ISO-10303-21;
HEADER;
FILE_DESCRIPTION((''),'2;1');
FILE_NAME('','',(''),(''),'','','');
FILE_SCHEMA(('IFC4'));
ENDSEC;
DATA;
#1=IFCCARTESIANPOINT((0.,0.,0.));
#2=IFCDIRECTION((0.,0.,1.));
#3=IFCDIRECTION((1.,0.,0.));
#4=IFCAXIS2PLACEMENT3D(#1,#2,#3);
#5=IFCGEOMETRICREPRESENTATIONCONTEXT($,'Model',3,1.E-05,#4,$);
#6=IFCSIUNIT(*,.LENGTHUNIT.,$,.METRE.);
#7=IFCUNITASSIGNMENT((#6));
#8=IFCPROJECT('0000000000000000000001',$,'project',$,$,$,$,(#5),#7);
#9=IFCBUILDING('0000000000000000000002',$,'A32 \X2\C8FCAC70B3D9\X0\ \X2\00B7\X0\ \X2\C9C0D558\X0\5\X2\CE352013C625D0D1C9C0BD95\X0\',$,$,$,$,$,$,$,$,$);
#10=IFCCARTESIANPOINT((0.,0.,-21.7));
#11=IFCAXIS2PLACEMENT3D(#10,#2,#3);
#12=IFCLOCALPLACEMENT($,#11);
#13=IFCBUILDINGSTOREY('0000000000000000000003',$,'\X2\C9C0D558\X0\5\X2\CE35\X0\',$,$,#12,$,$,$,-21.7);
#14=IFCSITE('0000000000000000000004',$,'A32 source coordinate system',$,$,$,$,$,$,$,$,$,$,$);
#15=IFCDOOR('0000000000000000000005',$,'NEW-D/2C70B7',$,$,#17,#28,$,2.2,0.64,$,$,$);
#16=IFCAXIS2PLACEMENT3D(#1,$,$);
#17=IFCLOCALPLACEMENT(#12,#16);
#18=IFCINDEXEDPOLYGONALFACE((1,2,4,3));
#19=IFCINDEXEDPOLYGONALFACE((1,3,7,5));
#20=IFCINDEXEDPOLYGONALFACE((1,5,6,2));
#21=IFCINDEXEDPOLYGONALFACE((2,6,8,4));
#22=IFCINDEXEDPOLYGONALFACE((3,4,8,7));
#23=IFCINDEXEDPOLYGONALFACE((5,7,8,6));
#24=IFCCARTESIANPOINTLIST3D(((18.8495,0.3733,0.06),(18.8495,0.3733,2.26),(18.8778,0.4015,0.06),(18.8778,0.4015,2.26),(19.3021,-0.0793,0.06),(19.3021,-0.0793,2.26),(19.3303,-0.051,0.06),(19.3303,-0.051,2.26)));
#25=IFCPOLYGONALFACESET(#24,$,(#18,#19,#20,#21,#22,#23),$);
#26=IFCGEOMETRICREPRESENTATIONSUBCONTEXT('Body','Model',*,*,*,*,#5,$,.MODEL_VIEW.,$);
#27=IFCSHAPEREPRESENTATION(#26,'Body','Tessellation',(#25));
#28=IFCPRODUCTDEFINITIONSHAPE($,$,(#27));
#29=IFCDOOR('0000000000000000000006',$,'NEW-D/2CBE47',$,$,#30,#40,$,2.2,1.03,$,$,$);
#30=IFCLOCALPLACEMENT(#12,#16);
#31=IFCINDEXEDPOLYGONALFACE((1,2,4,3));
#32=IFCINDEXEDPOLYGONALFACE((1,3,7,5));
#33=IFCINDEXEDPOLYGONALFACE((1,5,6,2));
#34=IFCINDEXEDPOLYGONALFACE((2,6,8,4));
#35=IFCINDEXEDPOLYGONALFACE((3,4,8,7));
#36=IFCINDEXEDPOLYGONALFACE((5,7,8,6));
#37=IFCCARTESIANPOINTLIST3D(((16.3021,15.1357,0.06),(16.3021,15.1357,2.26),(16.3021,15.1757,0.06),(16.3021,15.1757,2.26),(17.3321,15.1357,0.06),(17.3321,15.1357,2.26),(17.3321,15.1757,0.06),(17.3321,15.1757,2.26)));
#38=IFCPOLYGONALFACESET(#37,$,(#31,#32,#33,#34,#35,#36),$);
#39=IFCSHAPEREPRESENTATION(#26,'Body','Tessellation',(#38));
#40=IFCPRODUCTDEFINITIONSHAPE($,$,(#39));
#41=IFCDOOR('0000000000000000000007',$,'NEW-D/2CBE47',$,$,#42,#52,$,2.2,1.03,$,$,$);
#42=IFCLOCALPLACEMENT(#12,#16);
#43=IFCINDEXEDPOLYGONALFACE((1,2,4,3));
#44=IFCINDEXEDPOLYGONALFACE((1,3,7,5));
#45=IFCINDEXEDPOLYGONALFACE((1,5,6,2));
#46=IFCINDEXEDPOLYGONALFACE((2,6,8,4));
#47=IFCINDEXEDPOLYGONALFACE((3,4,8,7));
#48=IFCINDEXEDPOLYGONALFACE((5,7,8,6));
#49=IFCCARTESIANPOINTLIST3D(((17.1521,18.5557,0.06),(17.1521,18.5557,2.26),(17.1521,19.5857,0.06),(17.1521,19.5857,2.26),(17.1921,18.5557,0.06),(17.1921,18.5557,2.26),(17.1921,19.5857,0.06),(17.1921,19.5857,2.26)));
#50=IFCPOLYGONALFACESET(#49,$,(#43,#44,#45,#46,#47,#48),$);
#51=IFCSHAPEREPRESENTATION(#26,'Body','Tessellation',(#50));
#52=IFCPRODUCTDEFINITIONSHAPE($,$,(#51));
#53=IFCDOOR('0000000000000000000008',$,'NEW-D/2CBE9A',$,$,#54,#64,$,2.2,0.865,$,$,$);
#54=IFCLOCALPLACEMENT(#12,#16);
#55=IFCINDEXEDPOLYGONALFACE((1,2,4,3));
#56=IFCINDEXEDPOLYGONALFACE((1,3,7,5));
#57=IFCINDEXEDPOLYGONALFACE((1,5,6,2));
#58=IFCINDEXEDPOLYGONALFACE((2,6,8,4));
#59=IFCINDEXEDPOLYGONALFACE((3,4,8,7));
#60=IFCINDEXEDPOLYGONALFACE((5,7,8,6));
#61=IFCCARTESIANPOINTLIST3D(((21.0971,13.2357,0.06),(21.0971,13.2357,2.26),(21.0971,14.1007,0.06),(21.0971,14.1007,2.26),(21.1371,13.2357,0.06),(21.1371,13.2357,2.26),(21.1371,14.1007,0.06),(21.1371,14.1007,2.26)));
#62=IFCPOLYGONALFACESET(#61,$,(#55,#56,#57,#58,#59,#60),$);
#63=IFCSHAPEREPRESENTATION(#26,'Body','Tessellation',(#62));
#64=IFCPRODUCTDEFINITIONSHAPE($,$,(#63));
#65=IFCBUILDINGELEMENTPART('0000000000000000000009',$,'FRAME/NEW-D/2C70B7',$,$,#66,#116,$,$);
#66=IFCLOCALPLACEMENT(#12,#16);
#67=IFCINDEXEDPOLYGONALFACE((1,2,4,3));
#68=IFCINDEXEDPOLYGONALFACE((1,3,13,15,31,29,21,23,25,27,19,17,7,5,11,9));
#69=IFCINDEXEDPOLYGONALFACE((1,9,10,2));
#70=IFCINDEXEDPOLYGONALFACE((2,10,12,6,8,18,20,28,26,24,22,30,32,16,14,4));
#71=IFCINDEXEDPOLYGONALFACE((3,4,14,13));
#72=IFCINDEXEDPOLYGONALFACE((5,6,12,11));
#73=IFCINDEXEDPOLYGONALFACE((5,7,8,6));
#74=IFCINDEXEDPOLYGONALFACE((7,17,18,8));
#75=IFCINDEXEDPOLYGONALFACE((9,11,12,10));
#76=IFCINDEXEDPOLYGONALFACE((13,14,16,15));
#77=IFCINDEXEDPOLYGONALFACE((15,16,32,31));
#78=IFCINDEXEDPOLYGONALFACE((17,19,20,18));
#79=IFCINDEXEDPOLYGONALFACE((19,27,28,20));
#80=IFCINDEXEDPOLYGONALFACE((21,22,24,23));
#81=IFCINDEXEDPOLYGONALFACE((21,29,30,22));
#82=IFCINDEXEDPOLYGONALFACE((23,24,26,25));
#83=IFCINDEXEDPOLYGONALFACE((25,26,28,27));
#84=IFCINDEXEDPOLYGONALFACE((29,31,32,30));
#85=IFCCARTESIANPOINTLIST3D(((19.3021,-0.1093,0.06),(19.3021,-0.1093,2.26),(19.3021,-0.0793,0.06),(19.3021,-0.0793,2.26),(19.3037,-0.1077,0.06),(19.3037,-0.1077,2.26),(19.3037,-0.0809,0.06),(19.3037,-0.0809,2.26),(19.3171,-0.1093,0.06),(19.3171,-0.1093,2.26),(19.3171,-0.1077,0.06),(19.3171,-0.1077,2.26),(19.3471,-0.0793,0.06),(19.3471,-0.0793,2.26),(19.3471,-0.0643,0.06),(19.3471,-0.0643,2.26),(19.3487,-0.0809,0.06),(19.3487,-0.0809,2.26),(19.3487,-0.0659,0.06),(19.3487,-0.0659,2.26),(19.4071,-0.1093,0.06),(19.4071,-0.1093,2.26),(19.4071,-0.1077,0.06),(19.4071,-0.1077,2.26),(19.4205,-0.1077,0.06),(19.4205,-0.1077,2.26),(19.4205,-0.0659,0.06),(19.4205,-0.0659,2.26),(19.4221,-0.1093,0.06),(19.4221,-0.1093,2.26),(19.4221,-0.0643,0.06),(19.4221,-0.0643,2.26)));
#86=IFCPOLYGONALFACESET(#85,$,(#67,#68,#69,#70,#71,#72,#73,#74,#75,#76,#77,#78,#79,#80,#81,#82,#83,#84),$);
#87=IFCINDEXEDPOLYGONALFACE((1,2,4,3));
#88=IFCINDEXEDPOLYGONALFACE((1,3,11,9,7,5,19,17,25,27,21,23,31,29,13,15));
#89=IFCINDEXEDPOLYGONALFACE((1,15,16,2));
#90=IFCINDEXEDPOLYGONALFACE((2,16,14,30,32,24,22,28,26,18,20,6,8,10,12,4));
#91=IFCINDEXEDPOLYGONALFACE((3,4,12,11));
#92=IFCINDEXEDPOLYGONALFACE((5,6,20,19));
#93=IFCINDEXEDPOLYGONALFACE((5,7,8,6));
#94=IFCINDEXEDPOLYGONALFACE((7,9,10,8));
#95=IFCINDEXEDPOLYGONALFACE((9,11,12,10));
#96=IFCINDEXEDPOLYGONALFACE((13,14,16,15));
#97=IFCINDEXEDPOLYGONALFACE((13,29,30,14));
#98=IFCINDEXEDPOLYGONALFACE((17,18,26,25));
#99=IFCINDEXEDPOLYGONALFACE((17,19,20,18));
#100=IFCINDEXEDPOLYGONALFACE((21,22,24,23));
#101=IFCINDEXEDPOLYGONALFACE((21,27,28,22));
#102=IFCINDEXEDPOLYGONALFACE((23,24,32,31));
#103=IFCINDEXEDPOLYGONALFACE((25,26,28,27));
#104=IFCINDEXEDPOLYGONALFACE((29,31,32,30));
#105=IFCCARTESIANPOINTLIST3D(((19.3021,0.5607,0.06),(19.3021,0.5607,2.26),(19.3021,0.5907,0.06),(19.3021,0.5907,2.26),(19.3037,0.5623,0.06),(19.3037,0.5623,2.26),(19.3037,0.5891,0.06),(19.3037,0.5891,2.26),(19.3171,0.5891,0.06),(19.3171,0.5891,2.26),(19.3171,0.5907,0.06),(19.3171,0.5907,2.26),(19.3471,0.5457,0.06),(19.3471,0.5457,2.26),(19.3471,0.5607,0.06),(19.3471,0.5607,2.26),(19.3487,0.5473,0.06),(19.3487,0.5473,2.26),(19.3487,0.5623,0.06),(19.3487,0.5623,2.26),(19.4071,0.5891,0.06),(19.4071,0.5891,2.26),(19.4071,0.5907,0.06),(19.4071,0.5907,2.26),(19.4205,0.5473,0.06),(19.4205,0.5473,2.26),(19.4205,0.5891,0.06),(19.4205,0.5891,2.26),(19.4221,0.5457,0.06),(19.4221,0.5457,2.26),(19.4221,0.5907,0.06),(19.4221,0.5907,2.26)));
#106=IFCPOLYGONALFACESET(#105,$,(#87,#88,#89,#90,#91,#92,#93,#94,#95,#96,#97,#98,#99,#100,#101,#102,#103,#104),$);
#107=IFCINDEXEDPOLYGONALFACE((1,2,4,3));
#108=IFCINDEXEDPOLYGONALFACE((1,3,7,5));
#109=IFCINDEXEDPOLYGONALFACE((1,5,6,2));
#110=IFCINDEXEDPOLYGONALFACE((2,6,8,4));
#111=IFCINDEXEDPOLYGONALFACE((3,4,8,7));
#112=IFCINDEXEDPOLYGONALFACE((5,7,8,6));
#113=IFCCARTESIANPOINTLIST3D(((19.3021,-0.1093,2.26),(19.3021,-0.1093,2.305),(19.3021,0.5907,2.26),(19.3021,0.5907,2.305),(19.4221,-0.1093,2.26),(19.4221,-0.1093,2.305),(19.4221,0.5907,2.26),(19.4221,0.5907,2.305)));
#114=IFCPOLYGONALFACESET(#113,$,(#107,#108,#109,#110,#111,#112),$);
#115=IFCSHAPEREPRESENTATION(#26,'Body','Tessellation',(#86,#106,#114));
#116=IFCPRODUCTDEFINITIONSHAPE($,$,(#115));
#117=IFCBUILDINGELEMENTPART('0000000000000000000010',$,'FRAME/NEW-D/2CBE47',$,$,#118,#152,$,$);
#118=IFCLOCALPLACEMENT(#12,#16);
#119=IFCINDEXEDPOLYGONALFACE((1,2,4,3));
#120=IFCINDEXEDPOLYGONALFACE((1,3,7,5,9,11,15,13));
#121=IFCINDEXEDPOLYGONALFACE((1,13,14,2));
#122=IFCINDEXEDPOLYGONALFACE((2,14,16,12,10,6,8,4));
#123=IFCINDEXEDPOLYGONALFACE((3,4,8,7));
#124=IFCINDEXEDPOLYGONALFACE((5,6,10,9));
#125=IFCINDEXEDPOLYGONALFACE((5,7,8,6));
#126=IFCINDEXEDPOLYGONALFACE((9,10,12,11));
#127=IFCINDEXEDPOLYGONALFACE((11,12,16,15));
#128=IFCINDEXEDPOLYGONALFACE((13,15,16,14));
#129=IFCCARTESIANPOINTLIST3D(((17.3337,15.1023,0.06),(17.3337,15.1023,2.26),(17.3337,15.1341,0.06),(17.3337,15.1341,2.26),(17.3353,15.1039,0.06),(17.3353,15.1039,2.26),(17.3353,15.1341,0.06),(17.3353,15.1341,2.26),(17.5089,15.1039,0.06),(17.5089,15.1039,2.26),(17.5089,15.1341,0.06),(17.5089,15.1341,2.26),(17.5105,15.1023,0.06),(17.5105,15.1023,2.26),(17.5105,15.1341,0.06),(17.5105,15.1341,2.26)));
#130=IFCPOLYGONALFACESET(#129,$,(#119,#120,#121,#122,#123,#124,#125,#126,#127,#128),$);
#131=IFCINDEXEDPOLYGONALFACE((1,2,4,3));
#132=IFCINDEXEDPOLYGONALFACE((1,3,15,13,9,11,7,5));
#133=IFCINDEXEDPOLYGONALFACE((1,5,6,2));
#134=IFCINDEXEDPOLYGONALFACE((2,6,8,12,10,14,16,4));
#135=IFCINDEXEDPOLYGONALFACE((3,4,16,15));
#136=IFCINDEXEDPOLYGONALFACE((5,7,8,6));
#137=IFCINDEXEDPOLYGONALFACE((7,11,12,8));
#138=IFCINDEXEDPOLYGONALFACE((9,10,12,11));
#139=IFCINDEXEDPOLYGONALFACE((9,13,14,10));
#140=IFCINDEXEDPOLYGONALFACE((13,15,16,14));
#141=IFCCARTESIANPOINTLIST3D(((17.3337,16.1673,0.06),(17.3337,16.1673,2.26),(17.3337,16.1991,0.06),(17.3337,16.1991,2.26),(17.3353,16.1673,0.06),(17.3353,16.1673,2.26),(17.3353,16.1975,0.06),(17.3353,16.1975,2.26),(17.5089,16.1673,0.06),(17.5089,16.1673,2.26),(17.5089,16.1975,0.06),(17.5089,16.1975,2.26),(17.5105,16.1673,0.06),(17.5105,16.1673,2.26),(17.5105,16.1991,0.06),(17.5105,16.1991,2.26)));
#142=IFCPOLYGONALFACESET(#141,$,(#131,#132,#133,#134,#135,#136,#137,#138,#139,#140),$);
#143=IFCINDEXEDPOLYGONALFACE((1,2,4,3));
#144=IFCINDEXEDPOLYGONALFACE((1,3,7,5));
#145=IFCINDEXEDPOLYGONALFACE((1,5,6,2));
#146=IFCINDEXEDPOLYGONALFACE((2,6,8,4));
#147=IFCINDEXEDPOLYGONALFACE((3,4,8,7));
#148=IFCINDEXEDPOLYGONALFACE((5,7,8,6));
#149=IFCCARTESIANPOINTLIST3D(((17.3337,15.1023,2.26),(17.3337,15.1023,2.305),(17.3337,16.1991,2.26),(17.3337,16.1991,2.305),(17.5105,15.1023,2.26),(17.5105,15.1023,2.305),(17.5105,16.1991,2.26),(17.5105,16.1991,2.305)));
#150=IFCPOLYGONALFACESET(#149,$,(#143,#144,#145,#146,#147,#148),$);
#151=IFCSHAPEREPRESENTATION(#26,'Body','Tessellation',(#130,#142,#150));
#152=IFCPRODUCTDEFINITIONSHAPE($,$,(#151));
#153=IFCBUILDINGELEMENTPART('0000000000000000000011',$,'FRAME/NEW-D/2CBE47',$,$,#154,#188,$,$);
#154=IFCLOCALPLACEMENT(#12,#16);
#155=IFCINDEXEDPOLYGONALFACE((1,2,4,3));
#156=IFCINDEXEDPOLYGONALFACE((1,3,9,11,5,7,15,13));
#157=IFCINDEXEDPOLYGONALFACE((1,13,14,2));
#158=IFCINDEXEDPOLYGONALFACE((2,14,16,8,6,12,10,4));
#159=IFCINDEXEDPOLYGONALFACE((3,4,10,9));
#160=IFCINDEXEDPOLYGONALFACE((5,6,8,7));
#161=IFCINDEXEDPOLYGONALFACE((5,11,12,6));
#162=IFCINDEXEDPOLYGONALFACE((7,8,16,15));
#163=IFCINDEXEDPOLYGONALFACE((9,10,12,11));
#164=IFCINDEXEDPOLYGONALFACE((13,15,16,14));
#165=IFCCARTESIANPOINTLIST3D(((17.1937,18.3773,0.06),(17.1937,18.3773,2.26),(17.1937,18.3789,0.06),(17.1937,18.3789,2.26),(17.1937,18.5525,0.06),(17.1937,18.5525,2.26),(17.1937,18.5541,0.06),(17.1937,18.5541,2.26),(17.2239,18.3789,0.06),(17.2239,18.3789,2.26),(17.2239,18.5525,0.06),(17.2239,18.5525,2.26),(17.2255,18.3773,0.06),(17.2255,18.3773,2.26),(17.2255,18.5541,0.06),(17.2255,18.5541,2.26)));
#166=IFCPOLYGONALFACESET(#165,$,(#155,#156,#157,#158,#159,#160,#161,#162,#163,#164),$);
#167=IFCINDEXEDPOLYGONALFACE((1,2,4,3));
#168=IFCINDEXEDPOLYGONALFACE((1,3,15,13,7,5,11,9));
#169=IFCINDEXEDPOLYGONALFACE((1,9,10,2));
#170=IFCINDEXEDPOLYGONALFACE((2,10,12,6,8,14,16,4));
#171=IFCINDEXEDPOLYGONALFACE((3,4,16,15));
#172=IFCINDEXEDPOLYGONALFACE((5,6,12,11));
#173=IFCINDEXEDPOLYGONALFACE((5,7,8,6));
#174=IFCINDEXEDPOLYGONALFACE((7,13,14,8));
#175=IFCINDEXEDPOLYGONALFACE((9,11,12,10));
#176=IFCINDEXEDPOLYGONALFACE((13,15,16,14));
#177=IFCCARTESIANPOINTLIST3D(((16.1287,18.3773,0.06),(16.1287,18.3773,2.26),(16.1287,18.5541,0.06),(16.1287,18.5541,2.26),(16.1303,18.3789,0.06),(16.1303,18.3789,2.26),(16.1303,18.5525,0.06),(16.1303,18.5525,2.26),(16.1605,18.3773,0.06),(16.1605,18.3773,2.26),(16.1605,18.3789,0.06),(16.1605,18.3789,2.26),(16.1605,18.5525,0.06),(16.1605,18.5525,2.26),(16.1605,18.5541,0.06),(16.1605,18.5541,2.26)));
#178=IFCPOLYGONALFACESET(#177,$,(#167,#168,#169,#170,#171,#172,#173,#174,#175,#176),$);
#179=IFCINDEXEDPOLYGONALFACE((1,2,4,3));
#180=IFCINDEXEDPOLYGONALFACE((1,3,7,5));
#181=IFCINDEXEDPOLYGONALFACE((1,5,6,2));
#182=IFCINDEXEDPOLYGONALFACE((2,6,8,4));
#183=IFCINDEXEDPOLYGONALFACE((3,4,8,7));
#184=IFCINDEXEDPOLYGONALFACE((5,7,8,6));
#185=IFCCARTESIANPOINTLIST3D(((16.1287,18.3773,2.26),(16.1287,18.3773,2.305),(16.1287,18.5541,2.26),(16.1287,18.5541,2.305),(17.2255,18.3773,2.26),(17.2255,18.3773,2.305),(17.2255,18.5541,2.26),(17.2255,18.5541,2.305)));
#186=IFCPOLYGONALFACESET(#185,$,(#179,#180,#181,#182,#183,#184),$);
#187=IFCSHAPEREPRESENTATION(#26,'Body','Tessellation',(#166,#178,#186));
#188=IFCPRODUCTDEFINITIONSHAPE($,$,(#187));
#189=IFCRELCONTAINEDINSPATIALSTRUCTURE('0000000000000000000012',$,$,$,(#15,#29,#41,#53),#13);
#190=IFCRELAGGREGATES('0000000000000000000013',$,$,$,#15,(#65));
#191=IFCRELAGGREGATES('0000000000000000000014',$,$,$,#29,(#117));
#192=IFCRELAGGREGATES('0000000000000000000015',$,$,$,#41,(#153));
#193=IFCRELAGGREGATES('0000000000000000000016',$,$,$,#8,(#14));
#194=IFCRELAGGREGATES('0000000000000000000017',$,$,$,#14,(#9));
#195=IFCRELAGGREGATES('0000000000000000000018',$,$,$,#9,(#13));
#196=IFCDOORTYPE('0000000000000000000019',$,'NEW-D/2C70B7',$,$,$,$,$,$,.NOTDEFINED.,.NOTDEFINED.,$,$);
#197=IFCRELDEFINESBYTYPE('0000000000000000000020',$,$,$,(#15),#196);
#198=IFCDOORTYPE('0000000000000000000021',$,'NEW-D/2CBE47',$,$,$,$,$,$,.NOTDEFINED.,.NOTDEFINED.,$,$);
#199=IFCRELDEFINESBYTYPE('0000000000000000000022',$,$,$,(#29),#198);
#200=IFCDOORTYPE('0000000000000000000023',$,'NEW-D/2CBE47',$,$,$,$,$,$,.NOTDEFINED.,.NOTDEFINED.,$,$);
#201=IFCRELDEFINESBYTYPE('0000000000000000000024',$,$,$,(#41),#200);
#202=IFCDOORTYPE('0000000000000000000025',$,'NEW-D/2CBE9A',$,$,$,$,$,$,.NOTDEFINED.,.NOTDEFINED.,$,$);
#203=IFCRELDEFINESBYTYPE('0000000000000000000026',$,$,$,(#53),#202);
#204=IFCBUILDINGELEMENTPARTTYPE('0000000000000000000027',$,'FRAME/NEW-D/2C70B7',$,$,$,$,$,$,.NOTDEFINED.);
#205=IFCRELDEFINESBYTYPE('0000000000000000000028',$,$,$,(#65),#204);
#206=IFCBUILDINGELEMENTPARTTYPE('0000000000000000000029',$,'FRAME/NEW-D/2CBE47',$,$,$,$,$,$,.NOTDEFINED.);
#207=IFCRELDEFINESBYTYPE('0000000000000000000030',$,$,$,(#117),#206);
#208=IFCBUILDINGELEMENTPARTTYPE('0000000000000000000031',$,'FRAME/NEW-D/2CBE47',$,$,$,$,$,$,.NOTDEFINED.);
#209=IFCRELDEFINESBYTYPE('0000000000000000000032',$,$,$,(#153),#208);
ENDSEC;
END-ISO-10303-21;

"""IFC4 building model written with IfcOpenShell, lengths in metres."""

from ifc_helpers import new_model, si_unit, frame, origin, origin_with_axes, place, context, subcontext, project, spatial, polyline, outline, extrude, source, transform, mapped, type_object, type_shapes, element, aggregate, save


model = new_model("IFC4")

# Units and contexts
model_context = context("Model", 3, precision=1e-05, world=origin_with_axes())
body_context = subcontext(model_context, "Body", "Model", "MODEL_VIEW")
ifc_project = project(units=[si_unit("LENGTHUNIT", "METRE")], contexts=[model_context])

# Site, building, storey
site = spatial("IfcSite", under=ifc_project, Name="A32 source coordinate system")
building = spatial("IfcBuilding", under=site, Name="A32 주거동 · 지하5층–옥탑지붕")
storey_placement = place(None, frame((0.0, 0.0, -21.7), z_axis=(0.0, 0.0, 1.0), x_axis=(1.0, 0.0, 0.0)))
storey = spatial("IfcBuildingStorey", under=building, at=storey_placement, Name="지하5층", Elevation=-21.7)

# Doors
door_type_1 = type_object("IfcDoorType", Name="NEW-D/2C70B7", OperationType="NOTDEFINED", PredefinedType="NOTDEFINED")
shared_shape_1 = source(origin(), body_context, "Body", "SweptSolid", [
    extrude(outline(polyline([(18.8778, 0.4015), (19.3303, -0.051), (19.3021, -0.0793), (18.8495, 0.3733), (18.8778, 0.4015)])), frame((0.0, 0.0, 0.06)), (0.0, 0.0, 1.0), 2.2),
])
type_shapes(door_type_1, [shared_shape_1])
door_1_placement = place(storey_placement, origin_with_axes())
door_1 = element("IfcDoor", 1, at=door_1_placement, inside=storey, type_object=door_type_1, Name="NEW-D/2C70B7", OverallHeight=2.2, OverallWidth=0.64, context=body_context, shape_type="MappedRepresentation", body=[
    mapped(shared_shape_1, transform((0.0, 0.0, 0.0), scale=1.0)),
])
door_type_2 = type_object("IfcDoorType", Name="NEW-D/2CBE47", OperationType="NOTDEFINED", PredefinedType="NOTDEFINED")
shared_shape_2 = source(origin(), body_context, "Body", "SweptSolid", [
    extrude(outline(polyline([(16.3021, 15.1757), (17.3321, 15.1757), (17.3321, 15.1357), (16.3021, 15.1357), (16.3021, 15.1757)])), frame((0.0, 0.0, 0.06)), (0.0, 0.0, 1.0), 2.2),
])
type_shapes(door_type_2, [shared_shape_2])
door_2_placement = place(storey_placement, origin_with_axes())
door_2 = element("IfcDoor", 2, at=door_2_placement, inside=storey, type_object=door_type_2, Name="NEW-D/2CBE47", OverallHeight=2.2, OverallWidth=1.03, context=body_context, shape_type="MappedRepresentation", body=[
    mapped(shared_shape_2, transform((0.0, 0.0, 0.0), scale=1.0)),
])
door_type_3 = type_object("IfcDoorType", Name="NEW-D/2CBE47", OperationType="NOTDEFINED", PredefinedType="NOTDEFINED")
shared_shape_3 = source(origin(), body_context, "Body", "SweptSolid", [
    extrude(outline(polyline([(17.1921, 18.5557), (17.1521, 18.5557), (17.1521, 19.5857), (17.1921, 19.5857), (17.1921, 18.5557)])), frame((0.0, 0.0, 0.06)), (0.0, 0.0, 1.0), 2.2),
])
type_shapes(door_type_3, [shared_shape_3])
door_3_placement = place(storey_placement, origin_with_axes())
door_3 = element("IfcDoor", 3, at=door_3_placement, inside=storey, type_object=door_type_3, Name="NEW-D/2CBE47", OverallHeight=2.2, OverallWidth=1.03, context=body_context, shape_type="MappedRepresentation", body=[
    mapped(shared_shape_3, transform((0.0, 0.0, 0.0), scale=1.0)),
])

# Door
door_type_4 = type_object("IfcDoorType", Name="NEW-D/2CBE9A", OperationType="NOTDEFINED", PredefinedType="NOTDEFINED")
shared_shape_4 = source(origin(), body_context, "Body", "SweptSolid", [
    extrude(outline(polyline([(21.1371, 13.2357), (21.0971, 13.2357), (21.0971, 14.1007), (21.1371, 14.1007), (21.1371, 13.2357)])), frame((0.0, 0.0, 0.06)), (0.0, 0.0, 1.0), 2.2),
])
type_shapes(door_type_4, [shared_shape_4])
door_4_placement = place(storey_placement, origin_with_axes())
element("IfcDoor", 4, at=door_4_placement, inside=storey, type_object=door_type_4, Name="NEW-D/2CBE9A", OverallHeight=2.2, OverallWidth=0.865, context=body_context, shape_type="MappedRepresentation", body=[
    mapped(shared_shape_4, transform((0.0, 0.0, 0.0), scale=1.0)),
])

# Building element parts
building_element_part_type_1 = type_object("IfcBuildingElementPartType", Name="FRAME/NEW-D/2C70B7", PredefinedType="NOTDEFINED")
shared_shape_5 = source(origin(), body_context, "Body", "SweptSolid", [
    extrude(outline(polyline([(19.3021, -0.1093), (19.3021, -0.0793), (19.3471, -0.0793), (19.3471, -0.0643), (19.4221, -0.0643), (19.4221, -0.1093), (19.4071, -0.1093), (19.4071, -0.1077), (19.4205, -0.1077), (19.4205, -0.0659), (19.3487, -0.0659), (19.3487, -0.0809), (19.3037, -0.0809), (19.3037, -0.1077), (19.3171, -0.1077), (19.3171, -0.1093), (19.3021, -0.1093)])), frame((0.0, 0.0, 0.06)), (0.0, 0.0, 1.0), 2.2),
    extrude(outline(polyline([(19.3037, 0.5623), (19.3487, 0.5623), (19.3487, 0.5473), (19.4205, 0.5473), (19.4205, 0.5891), (19.4071, 0.5891), (19.4071, 0.5907), (19.4221, 0.5907), (19.4221, 0.5457), (19.3471, 0.5457), (19.3471, 0.5607), (19.3021, 0.5607), (19.3021, 0.5907), (19.3171, 0.5907), (19.3171, 0.5891), (19.3037, 0.5891), (19.3037, 0.5623)])), frame((0.0, 0.0, 0.06)), (0.0, 0.0, 1.0), 2.2),
    extrude(outline(polyline([(19.4221, -0.1093), (19.4221, 0.5907), (19.3021, 0.5907), (19.3021, -0.1093), (19.4221, -0.1093)])), frame((0.0, 0.0, 2.26)), (0.0, 0.0, 1.0), 0.045),
])
type_shapes(building_element_part_type_1, [shared_shape_5])
building_element_part_1_placement = place(door_1_placement, origin_with_axes())
building_element_part_1 = element("IfcBuildingElementPart", 5, at=building_element_part_1_placement, type_object=building_element_part_type_1, Name="FRAME/NEW-D/2C70B7", context=body_context, shape_type="MappedRepresentation", body=[
    mapped(shared_shape_5, transform((0.0, 0.0, 0.0), scale=1.0)),
])
aggregate(door_1, [building_element_part_1])
building_element_part_type_2 = type_object("IfcBuildingElementPartType", Name="FRAME/NEW-D/2CBE47", PredefinedType="NOTDEFINED")
shared_shape_6 = source(origin(), body_context, "Body", "SweptSolid", [
    extrude(outline(polyline([(17.3353, 15.1039), (17.5089, 15.1039), (17.5089, 15.1341), (17.5105, 15.1341), (17.5105, 15.1023), (17.3337, 15.1023), (17.3337, 15.1341), (17.3353, 15.1341), (17.3353, 15.1039)])), frame((0.0, 0.0, 0.06)), (0.0, 0.0, 1.0), 2.2),
    extrude(outline(polyline([(17.5105, 16.1991), (17.5105, 16.1673), (17.5089, 16.1673), (17.5089, 16.1975), (17.3353, 16.1975), (17.3353, 16.1673), (17.3337, 16.1673), (17.3337, 16.1991), (17.5105, 16.1991)])), frame((0.0, 0.0, 0.06)), (0.0, 0.0, 1.0), 2.2),
    extrude(outline(polyline([(17.5105, 15.1023), (17.5105, 16.1991), (17.3337, 16.1991), (17.3337, 15.1023), (17.5105, 15.1023)])), frame((0.0, 0.0, 2.26)), (0.0, 0.0, 1.0), 0.045),
])
type_shapes(building_element_part_type_2, [shared_shape_6])
building_element_part_2_placement = place(door_2_placement, origin_with_axes())
building_element_part_2 = element("IfcBuildingElementPart", 6, at=building_element_part_2_placement, type_object=building_element_part_type_2, Name="FRAME/NEW-D/2CBE47", context=body_context, shape_type="MappedRepresentation", body=[
    mapped(shared_shape_6, transform((0.0, 0.0, 0.0), scale=1.0)),
])
aggregate(door_2, [building_element_part_2])
building_element_part_type_3 = type_object("IfcBuildingElementPartType", Name="FRAME/NEW-D/2CBE47", PredefinedType="NOTDEFINED")
shared_shape_7 = source(origin(), body_context, "Body", "SweptSolid", [
    extrude(outline(polyline([(17.2255, 18.3773), (17.1937, 18.3773), (17.1937, 18.3789), (17.2239, 18.3789), (17.2239, 18.5525), (17.1937, 18.5525), (17.1937, 18.5541), (17.2255, 18.5541), (17.2255, 18.3773)])), frame((0.0, 0.0, 0.06)), (0.0, 0.0, 1.0), 2.2),
    extrude(outline(polyline([(16.1303, 18.5525), (16.1303, 18.3789), (16.1605, 18.3789), (16.1605, 18.3773), (16.1287, 18.3773), (16.1287, 18.5541), (16.1605, 18.5541), (16.1605, 18.5525), (16.1303, 18.5525)])), frame((0.0, 0.0, 0.06)), (0.0, 0.0, 1.0), 2.2),
    extrude(outline(polyline([(17.2255, 18.3773), (17.2255, 18.5541), (16.1287, 18.5541), (16.1287, 18.3773), (17.2255, 18.3773)])), frame((0.0, 0.0, 2.26)), (0.0, 0.0, 1.0), 0.045),
])
type_shapes(building_element_part_type_3, [shared_shape_7])
building_element_part_3_placement = place(door_3_placement, origin_with_axes())
building_element_part_3 = element("IfcBuildingElementPart", 7, at=building_element_part_3_placement, type_object=building_element_part_type_3, Name="FRAME/NEW-D/2CBE47", context=body_context, shape_type="MappedRepresentation", body=[
    mapped(shared_shape_7, transform((0.0, 0.0, 0.0), scale=1.0)),
])
aggregate(door_3, [building_element_part_3])

save(model, "model.ifc")
